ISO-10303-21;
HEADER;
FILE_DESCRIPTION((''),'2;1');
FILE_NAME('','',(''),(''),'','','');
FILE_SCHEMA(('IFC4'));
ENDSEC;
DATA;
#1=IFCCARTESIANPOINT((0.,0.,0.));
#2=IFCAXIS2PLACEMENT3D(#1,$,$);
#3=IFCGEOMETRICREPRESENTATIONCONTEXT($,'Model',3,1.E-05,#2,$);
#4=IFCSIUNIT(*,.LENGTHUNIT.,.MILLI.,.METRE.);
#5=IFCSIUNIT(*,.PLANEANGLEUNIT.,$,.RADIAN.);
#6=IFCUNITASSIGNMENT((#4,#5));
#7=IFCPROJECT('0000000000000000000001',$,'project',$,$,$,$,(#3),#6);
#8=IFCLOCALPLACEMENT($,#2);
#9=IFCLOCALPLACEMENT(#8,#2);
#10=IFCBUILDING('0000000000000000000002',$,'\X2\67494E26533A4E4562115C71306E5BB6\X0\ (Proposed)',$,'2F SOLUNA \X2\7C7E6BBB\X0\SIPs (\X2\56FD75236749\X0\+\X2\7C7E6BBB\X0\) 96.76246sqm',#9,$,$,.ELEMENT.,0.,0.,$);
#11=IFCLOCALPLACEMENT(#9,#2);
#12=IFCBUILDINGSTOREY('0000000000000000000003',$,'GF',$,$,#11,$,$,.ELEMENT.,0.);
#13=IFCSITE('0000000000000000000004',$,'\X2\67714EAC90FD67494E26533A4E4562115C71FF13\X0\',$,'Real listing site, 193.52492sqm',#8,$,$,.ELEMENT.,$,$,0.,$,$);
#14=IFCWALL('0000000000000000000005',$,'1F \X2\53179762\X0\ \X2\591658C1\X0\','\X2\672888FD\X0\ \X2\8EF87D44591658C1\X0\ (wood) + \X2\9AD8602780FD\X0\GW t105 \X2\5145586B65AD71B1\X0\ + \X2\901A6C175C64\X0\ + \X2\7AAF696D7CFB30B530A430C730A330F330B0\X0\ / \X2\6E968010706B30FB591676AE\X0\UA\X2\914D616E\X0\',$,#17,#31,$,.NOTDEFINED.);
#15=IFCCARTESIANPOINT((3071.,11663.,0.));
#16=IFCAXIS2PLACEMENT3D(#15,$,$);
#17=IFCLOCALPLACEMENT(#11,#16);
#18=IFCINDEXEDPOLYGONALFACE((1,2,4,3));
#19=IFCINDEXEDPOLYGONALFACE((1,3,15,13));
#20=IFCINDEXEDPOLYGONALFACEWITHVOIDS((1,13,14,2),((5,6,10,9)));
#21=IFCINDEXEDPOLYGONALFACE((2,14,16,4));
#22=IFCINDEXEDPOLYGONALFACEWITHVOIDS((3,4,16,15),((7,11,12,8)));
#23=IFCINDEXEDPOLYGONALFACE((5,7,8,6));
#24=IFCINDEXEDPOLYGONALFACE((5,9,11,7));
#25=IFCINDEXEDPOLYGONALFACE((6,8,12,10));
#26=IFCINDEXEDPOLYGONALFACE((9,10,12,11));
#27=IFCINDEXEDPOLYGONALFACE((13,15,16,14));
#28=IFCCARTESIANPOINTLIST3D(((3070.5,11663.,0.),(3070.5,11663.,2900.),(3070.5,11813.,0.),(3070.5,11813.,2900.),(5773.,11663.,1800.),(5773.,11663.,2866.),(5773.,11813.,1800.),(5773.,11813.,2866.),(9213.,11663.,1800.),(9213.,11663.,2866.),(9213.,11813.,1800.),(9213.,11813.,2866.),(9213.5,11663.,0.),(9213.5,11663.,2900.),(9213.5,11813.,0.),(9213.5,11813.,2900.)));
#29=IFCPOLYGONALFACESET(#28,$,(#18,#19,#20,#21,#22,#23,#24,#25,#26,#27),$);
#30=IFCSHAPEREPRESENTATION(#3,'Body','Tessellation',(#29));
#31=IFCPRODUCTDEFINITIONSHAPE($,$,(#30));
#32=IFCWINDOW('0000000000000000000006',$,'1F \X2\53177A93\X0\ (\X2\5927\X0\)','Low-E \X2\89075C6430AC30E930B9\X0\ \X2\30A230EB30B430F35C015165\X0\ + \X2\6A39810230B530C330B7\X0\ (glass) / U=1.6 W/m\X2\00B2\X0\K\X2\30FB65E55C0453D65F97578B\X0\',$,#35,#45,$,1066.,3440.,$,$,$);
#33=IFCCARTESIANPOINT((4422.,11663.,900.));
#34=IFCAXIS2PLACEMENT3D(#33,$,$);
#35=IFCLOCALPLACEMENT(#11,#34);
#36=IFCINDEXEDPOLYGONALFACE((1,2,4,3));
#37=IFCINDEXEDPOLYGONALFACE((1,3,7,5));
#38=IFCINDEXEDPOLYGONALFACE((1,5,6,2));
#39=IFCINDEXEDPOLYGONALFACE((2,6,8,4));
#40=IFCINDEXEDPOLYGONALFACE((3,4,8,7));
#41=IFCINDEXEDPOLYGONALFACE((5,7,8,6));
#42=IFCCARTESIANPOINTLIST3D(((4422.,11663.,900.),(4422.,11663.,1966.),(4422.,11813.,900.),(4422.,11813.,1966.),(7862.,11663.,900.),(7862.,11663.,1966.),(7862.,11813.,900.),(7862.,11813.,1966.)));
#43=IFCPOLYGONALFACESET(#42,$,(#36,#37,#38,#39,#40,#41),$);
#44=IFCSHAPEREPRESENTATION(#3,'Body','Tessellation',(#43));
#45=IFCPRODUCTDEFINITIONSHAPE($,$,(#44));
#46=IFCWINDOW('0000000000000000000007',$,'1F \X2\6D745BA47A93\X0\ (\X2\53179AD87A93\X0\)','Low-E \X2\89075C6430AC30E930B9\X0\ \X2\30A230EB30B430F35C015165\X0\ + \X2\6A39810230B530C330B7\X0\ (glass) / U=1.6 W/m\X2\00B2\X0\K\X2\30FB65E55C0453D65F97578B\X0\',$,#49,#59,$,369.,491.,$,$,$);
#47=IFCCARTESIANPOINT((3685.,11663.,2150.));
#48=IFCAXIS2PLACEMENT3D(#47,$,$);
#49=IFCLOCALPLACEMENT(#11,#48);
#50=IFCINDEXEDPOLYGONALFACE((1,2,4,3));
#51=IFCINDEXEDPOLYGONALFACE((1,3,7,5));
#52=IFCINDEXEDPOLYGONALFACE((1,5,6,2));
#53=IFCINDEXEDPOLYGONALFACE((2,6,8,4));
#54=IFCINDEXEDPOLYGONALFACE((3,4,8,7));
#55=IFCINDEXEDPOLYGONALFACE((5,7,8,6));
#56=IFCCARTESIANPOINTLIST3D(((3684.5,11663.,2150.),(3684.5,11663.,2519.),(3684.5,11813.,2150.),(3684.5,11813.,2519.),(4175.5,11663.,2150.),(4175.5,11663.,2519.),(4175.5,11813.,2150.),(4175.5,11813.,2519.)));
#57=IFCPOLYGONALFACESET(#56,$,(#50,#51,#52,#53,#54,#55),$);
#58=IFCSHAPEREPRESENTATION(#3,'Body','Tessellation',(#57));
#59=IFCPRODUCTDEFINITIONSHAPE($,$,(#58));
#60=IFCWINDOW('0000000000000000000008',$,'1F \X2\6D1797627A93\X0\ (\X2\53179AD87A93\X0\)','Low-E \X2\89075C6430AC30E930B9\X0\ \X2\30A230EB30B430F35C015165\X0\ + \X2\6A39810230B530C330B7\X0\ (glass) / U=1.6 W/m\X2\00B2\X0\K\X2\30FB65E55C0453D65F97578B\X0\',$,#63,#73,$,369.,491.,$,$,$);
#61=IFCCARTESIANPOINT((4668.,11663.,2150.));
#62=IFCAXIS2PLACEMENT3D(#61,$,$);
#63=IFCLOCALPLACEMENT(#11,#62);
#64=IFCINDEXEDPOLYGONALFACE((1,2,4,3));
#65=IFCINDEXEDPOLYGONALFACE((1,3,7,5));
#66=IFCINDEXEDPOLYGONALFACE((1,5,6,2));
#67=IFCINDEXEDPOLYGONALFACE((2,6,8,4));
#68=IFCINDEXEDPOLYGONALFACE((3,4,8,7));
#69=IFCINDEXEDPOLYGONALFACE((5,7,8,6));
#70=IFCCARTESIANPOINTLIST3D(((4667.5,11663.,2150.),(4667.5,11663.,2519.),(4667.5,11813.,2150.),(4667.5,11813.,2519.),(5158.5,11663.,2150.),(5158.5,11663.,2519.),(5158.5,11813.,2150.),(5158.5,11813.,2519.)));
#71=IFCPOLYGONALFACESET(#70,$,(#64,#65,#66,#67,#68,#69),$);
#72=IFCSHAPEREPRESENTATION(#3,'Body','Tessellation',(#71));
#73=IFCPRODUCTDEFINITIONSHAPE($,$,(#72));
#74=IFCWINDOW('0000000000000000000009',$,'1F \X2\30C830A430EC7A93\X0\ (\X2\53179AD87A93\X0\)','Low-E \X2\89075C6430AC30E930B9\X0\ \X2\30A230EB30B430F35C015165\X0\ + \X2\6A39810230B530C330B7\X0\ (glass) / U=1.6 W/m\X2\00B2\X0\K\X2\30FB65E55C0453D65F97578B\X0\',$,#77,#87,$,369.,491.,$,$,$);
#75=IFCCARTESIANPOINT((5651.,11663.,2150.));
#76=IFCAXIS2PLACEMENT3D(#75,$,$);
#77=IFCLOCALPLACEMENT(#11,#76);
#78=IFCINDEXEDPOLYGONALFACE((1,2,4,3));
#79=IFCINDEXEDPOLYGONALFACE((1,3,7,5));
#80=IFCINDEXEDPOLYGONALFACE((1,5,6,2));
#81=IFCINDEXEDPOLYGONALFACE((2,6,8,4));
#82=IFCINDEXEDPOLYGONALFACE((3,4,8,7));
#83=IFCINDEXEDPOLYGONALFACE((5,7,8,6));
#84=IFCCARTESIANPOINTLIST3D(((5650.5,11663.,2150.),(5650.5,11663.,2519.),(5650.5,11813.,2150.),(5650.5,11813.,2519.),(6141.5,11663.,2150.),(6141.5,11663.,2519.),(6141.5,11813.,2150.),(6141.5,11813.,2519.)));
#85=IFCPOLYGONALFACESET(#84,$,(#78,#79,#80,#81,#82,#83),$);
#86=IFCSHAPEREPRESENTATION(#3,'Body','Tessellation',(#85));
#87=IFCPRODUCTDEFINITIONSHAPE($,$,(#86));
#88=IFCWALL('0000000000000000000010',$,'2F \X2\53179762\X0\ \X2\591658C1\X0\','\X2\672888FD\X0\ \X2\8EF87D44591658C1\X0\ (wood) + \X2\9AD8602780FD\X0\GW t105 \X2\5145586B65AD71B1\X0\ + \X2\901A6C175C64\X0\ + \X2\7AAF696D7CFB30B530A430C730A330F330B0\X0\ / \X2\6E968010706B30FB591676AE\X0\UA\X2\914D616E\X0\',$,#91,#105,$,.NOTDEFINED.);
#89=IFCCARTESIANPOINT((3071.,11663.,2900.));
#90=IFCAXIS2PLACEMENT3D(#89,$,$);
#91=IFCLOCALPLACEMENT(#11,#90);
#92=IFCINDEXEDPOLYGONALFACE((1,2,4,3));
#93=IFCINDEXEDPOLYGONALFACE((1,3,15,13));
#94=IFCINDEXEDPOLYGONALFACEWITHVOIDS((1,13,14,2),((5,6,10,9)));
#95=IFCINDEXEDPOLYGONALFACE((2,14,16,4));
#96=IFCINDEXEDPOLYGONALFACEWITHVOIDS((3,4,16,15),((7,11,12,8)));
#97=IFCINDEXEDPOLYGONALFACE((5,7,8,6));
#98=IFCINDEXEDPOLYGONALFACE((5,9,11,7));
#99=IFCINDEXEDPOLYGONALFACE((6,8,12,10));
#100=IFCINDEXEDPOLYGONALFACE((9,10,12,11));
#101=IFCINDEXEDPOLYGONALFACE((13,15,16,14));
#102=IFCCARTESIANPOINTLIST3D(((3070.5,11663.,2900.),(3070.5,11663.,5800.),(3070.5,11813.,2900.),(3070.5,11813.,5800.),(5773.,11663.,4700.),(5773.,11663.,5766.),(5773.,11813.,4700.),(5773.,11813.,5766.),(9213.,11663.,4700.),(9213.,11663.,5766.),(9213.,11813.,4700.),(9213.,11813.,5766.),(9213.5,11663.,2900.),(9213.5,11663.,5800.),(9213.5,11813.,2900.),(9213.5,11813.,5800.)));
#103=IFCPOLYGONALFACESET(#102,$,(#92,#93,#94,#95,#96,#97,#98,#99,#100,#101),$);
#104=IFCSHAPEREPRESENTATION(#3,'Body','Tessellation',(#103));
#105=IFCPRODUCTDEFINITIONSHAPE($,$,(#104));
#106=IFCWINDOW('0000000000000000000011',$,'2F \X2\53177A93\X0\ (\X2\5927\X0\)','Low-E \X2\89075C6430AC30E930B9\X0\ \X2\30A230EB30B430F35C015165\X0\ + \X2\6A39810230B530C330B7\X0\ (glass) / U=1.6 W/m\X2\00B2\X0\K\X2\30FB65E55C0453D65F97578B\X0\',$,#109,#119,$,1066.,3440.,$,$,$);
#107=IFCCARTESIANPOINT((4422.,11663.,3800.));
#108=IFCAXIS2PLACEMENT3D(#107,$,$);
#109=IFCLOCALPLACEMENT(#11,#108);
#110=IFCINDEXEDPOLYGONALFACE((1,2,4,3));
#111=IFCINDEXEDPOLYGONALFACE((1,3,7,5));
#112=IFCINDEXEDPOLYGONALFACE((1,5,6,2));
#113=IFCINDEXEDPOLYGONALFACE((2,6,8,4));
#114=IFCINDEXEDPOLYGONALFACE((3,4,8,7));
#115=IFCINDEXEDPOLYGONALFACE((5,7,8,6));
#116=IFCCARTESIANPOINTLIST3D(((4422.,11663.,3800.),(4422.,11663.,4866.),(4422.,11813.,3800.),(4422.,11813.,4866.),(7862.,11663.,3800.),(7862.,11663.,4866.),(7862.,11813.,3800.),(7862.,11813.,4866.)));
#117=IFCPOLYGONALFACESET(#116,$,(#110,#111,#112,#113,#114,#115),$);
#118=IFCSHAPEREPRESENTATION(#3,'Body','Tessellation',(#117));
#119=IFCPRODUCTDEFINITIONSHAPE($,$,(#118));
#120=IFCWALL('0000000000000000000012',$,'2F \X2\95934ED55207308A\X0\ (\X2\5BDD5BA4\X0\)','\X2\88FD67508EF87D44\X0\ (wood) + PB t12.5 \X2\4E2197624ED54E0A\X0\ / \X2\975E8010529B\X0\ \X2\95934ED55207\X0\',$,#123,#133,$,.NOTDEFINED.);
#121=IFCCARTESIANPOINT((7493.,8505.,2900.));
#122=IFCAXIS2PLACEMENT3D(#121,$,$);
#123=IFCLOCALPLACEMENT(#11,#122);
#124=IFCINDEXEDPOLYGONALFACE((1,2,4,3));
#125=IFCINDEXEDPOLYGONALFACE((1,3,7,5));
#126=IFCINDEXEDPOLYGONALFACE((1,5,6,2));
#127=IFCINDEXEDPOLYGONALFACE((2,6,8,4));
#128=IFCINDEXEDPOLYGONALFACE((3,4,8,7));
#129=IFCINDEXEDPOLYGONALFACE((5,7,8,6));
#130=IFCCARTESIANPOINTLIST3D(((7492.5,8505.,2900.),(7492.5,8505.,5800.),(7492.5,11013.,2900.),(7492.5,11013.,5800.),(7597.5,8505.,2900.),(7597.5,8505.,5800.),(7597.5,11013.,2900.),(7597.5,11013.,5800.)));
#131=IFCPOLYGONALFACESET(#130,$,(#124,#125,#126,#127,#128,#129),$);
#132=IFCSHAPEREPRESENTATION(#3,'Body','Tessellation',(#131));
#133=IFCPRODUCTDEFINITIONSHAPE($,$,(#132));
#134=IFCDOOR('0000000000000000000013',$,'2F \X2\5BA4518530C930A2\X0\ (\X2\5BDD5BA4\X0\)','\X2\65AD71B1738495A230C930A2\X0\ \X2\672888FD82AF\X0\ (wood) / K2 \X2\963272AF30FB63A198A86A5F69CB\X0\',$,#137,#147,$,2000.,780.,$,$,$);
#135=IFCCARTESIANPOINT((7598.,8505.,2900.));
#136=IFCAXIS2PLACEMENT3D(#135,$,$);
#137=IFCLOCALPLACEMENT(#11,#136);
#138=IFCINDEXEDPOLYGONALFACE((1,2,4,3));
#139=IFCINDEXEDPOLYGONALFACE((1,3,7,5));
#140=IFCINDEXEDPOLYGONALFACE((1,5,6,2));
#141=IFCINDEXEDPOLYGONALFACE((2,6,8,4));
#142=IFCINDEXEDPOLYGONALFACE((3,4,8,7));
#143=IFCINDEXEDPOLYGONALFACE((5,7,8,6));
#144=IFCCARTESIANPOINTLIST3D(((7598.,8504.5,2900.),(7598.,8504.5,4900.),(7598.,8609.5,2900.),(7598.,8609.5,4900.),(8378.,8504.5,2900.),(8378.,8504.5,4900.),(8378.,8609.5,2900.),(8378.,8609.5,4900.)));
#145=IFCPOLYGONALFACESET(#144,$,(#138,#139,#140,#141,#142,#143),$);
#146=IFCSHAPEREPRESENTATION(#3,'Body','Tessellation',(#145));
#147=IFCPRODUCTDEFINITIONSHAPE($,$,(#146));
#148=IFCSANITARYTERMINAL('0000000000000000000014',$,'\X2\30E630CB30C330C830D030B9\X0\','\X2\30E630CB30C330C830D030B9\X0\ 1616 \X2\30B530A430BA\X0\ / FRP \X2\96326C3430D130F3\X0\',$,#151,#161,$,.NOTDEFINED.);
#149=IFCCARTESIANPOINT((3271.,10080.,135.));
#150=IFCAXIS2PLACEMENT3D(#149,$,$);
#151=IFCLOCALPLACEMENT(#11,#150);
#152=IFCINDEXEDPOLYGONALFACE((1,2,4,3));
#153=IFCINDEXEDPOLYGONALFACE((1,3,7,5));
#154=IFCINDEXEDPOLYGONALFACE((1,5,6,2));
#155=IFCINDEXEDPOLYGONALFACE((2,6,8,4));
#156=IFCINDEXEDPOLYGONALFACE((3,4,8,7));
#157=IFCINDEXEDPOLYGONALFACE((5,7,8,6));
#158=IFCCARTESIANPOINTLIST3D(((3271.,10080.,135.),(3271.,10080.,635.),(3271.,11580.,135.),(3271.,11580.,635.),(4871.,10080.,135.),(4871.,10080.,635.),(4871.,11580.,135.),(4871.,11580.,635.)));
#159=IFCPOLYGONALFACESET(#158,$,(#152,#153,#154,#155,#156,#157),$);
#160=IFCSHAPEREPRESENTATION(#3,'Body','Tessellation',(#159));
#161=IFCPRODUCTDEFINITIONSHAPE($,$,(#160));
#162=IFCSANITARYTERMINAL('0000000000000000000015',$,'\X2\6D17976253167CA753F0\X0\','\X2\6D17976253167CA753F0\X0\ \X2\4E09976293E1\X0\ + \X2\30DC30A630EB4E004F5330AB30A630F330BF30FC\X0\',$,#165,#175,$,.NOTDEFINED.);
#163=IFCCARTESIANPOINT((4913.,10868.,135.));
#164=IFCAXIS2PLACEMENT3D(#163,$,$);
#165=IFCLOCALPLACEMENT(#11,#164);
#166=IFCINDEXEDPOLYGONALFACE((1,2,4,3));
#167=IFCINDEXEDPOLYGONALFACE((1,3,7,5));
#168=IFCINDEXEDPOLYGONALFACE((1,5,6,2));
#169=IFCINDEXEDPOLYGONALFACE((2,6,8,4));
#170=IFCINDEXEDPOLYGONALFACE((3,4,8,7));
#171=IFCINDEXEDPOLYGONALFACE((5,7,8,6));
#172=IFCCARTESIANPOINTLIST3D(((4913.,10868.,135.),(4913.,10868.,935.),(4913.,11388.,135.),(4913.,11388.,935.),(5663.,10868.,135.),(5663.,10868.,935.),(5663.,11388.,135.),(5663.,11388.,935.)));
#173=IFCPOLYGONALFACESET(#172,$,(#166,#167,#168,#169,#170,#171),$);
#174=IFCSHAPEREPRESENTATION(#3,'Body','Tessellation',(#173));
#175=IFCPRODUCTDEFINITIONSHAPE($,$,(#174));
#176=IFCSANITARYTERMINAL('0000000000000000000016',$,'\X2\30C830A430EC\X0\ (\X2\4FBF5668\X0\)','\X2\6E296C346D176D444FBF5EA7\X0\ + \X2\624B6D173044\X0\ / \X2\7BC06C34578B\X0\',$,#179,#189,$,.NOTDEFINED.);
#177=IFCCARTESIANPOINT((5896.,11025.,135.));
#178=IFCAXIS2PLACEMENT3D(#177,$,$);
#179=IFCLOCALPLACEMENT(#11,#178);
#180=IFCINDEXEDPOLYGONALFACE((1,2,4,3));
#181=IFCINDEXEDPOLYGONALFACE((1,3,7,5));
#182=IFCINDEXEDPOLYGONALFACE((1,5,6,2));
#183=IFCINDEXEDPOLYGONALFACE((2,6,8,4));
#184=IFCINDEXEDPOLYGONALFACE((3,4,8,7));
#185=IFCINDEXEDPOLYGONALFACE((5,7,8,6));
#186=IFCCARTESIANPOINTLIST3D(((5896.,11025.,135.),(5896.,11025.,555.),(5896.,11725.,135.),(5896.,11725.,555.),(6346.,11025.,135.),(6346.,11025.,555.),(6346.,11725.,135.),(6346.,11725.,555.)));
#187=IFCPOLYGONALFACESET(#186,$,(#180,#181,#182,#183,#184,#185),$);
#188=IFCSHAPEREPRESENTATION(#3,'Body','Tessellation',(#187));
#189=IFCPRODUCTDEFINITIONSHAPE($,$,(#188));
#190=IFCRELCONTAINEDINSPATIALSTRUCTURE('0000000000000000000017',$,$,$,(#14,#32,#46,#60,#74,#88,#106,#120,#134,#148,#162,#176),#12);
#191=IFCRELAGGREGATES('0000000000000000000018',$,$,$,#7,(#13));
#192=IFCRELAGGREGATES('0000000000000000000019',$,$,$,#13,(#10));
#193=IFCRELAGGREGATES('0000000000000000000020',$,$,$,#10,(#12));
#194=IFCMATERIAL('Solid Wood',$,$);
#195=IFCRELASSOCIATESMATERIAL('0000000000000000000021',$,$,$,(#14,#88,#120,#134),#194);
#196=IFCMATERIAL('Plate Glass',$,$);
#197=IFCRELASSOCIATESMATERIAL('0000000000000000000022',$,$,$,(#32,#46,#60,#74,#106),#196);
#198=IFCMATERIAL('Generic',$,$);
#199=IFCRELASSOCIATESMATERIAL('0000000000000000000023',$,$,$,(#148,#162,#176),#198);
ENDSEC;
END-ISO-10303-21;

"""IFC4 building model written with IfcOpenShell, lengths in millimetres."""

from ifc_helpers import new_model, si_unit, frame, frame_2d, origin, place, context, project, spatial, rectangle, extrude, material, element, fill, save


model = new_model("IFC4")

# Units and contexts
model_context = context("Model", 3, precision=1e-05, world=origin())
ifc_project = project(units=[si_unit("LENGTHUNIT", "METRE", prefix="MILLI"), si_unit("PLANEANGLEUNIT", "RADIAN")], contexts=[model_context])

# Site, building, storey
site_placement = place(None, origin())
site = spatial("IfcSite", under=ifc_project, at=site_placement, Name="東京都杉並区久我山３", ObjectType="Real listing site, 193.52492sqm", CompositionType="ELEMENT", RefElevation=0.0)
building_placement = place(site_placement, origin())
building = spatial("IfcBuilding", under=site, at=building_placement, Name="杉並区久我山の家 (Proposed)", ObjectType="2F SOLUNA 籾殻SIPs (国産杉+籾殻) 96.76246sqm", CompositionType="ELEMENT", ElevationOfRefHeight=0.0, ElevationOfTerrain=0.0)
storey_placement = place(building_placement, origin())
storey = spatial("IfcBuildingStorey", under=building, at=storey_placement, Name="GF", CompositionType="ELEMENT", Elevation=0.0)

# Wall, openings, windows
ifc_material_1 = material(Name="Solid Wood")
wall_1_placement = place(storey_placement, frame((3071.0, 11663.0, 0.0)))
wall_1 = element("IfcWall", 1, at=wall_1_placement, inside=storey, material=ifc_material_1, Name="1F 北面 外壁", Description="木製 軸組外壁 (wood) + 高性能GW t105 充填断熱 + 通気層 + 窯業系サイディング / 準耐火・外皮UA配慮", PredefinedType="NOTDEFINED", context=model_context, shape_type="SweptSolid", body=[
    extrude(rectangle(XDim=6143.0, YDim=150.0, at=frame_2d((3071.0, 75.0))), frame((3071.0, 11663.0, 0.0)), (0.0, 0.0, 1.0), 2900.0),
])
opening_1_placement = place(storey_placement, frame((4422.0, 11663.0, 900.0)))
opening_1 = element("IfcOpeningElement", 2, at=opening_1_placement, cuts=wall_1, PredefinedType="NOTDEFINED", context=model_context, shape_type="SweptSolid", body=[
    extrude(rectangle(XDim=3440.0, YDim=150.0, at=frame_2d((1720.0, 75.0))), frame((4422.0, 11663.0, 900.0)), (0.0, 0.0, 1.0), 1066.0),
])
opening_2_placement = place(storey_placement, frame((3685.0, 11663.0, 2150.0)))
opening_2 = element("IfcOpeningElement", 3, at=opening_2_placement, cuts=wall_1, PredefinedType="NOTDEFINED", context=model_context, shape_type="SweptSolid", body=[
    extrude(rectangle(XDim=491.0, YDim=150.0, at=frame_2d((245.0, 75.0))), frame((3685.0, 11663.0, 2150.0)), (0.0, 0.0, 1.0), 369.0),
])
opening_3_placement = place(storey_placement, frame((4668.0, 11663.0, 2150.0)))
opening_3 = element("IfcOpeningElement", 4, at=opening_3_placement, cuts=wall_1, PredefinedType="NOTDEFINED", context=model_context, shape_type="SweptSolid", body=[
    extrude(rectangle(XDim=491.0, YDim=150.0, at=frame_2d((245.0, 75.0))), frame((4668.0, 11663.0, 2150.0)), (0.0, 0.0, 1.0), 369.0),
])
opening_4_placement = place(storey_placement, frame((5651.0, 11663.0, 2150.0)))
opening_4 = element("IfcOpeningElement", 5, at=opening_4_placement, cuts=wall_1, PredefinedType="NOTDEFINED", context=model_context, shape_type="SweptSolid", body=[
    extrude(rectangle(XDim=491.0, YDim=150.0, at=frame_2d((245.0, 75.0))), frame((5651.0, 11663.0, 2150.0)), (0.0, 0.0, 1.0), 369.0),
])
ifc_material_2 = material(Name="Plate Glass")
window_1_placement = place(storey_placement, frame((4422.0, 11663.0, 900.0)))
window_1 = element("IfcWindow", 6, at=window_1_placement, inside=storey, material=ifc_material_2, Name="1F 北窓 (大)", Description="Low-E 複層ガラス アルゴン封入 + 樹脂サッシ (glass) / U=1.6 W/m²K・日射取得型", OverallHeight=1066.0, OverallWidth=3440.0, context=model_context, shape_type="SweptSolid", body=[
    extrude(rectangle(XDim=3440.0, YDim=150.0, at=frame_2d((1720.0, 75.0))), frame((4422.0, 11663.0, 900.0)), (0.0, 0.0, 1.0), 1066.0),
])
fill(opening_1, window_1)
window_2_placement = place(storey_placement, frame((3685.0, 11663.0, 2150.0)))
window_2 = element("IfcWindow", 7, at=window_2_placement, inside=storey, material=ifc_material_2, Name="1F 浴室窓 (北高窓)", Description="Low-E 複層ガラス アルゴン封入 + 樹脂サッシ (glass) / U=1.6 W/m²K・日射取得型", OverallHeight=369.0, OverallWidth=491.0, context=model_context, shape_type="SweptSolid", body=[
    extrude(rectangle(XDim=491.0, YDim=150.0, at=frame_2d((245.0, 75.0))), frame((3685.0, 11663.0, 2150.0)), (0.0, 0.0, 1.0), 369.0),
])
fill(opening_2, window_2)
window_3_placement = place(storey_placement, frame((4668.0, 11663.0, 2150.0)))
window_3 = element("IfcWindow", 8, at=window_3_placement, inside=storey, material=ifc_material_2, Name="1F 洗面窓 (北高窓)", Description="Low-E 複層ガラス アルゴン封入 + 樹脂サッシ (glass) / U=1.6 W/m²K・日射取得型", OverallHeight=369.0, OverallWidth=491.0, context=model_context, shape_type="SweptSolid", body=[
    extrude(rectangle(XDim=491.0, YDim=150.0, at=frame_2d((245.0, 75.0))), frame((4668.0, 11663.0, 2150.0)), (0.0, 0.0, 1.0), 369.0),
])
fill(opening_3, window_3)
window_4_placement = place(storey_placement, frame((5651.0, 11663.0, 2150.0)))
window_4 = element("IfcWindow", 9, at=window_4_placement, inside=storey, material=ifc_material_2, Name="1F トイレ窓 (北高窓)", Description="Low-E 複層ガラス アルゴン封入 + 樹脂サッシ (glass) / U=1.6 W/m²K・日射取得型", OverallHeight=369.0, OverallWidth=491.0, context=model_context, shape_type="SweptSolid", body=[
    extrude(rectangle(XDim=491.0, YDim=150.0, at=frame_2d((245.0, 75.0))), frame((5651.0, 11663.0, 2150.0)), (0.0, 0.0, 1.0), 369.0),
])
fill(opening_4, window_4)

# Wall, opening, window
wall_2_placement = place(storey_placement, frame((3071.0, 11663.0, 2900.0)))
wall_2 = element("IfcWall", 10, at=wall_2_placement, inside=storey, material=ifc_material_1, Name="2F 北面 外壁", Description="木製 軸組外壁 (wood) + 高性能GW t105 充填断熱 + 通気層 + 窯業系サイディング / 準耐火・外皮UA配慮", PredefinedType="NOTDEFINED", context=model_context, shape_type="SweptSolid", body=[
    extrude(rectangle(XDim=6143.0, YDim=150.0, at=frame_2d((3071.0, 75.0))), frame((3071.0, 11663.0, 2900.0)), (0.0, 0.0, 1.0), 2900.0),
])
opening_5_placement = place(storey_placement, frame((4422.0, 11663.0, 3800.0)))
opening_5 = element("IfcOpeningElement", 11, at=opening_5_placement, cuts=wall_2, PredefinedType="NOTDEFINED", context=model_context, shape_type="SweptSolid", body=[
    extrude(rectangle(XDim=3440.0, YDim=150.0, at=frame_2d((1720.0, 75.0))), frame((4422.0, 11663.0, 3800.0)), (0.0, 0.0, 1.0), 1066.0),
])
window_5_placement = place(storey_placement, frame((4422.0, 11663.0, 3800.0)))
window_5 = element("IfcWindow", 12, at=window_5_placement, inside=storey, material=ifc_material_2, Name="2F 北窓 (大)", Description="Low-E 複層ガラス アルゴン封入 + 樹脂サッシ (glass) / U=1.6 W/m²K・日射取得型", OverallHeight=1066.0, OverallWidth=3440.0, context=model_context, shape_type="SweptSolid", body=[
    extrude(rectangle(XDim=3440.0, YDim=150.0, at=frame_2d((1720.0, 75.0))), frame((4422.0, 11663.0, 3800.0)), (0.0, 0.0, 1.0), 1066.0),
])
fill(opening_5, window_5)

# Wall
wall_3_placement = place(storey_placement, frame((7493.0, 8505.0, 2900.0)))
element("IfcWall", 13, at=wall_3_placement, inside=storey, material=ifc_material_1, Name="2F 間仕切り (寝室)", Description="製材軸組 (wood) + PB t12.5 両面仕上 / 非耐力 間仕切", PredefinedType="NOTDEFINED", context=model_context, shape_type="SweptSolid", body=[
    extrude(rectangle(XDim=105.0, YDim=2508.0, at=frame_2d((52.0, 1254.0))), frame((7493.0, 8505.0, 2900.0)), (0.0, 0.0, 1.0), 2900.0),
])

# Door
door_1_placement = place(storey_placement, frame((7598.0, 8505.0, 2900.0)))
element("IfcDoor", 14, at=door_1_placement, inside=storey, material=ifc_material_1, Name="2F 室内ドア (寝室)", Description="断熱玄関ドア 木製芯 (wood) / K2 防犯・採風機構", OverallHeight=2000.0, OverallWidth=780.0, context=model_context, shape_type="SweptSolid", body=[
    extrude(rectangle(XDim=780.0, YDim=105.0, at=frame_2d((390.0, 52.0))), frame((7598.0, 8505.0, 2900.0)), (0.0, 0.0, 1.0), 2000.0),
])

# Sanitary terminals
ifc_material_3 = material(Name="Generic")
sanitary_terminal_1_placement = place(storey_placement, frame((3271.0, 10080.0, 135.0)))
element("IfcSanitaryTerminal", 15, at=sanitary_terminal_1_placement, inside=storey, material=ifc_material_3, Name="ユニットバス", Description="ユニットバス 1616 サイズ / FRP 防水パン", PredefinedType="NOTDEFINED", context=model_context, shape_type="SweptSolid", body=[
    extrude(rectangle(XDim=1600.0, YDim=1500.0, at=frame_2d((800.0, 750.0))), frame((3271.0, 10080.0, 135.0)), (0.0, 0.0, 1.0), 500.0),
])
sanitary_terminal_2_placement = place(storey_placement, frame((4913.0, 10868.0, 135.0)))
element("IfcSanitaryTerminal", 16, at=sanitary_terminal_2_placement, inside=storey, material=ifc_material_3, Name="洗面化粧台", Description="洗面化粧台 三面鏡 + ボウル一体カウンター", PredefinedType="NOTDEFINED", context=model_context, shape_type="SweptSolid", body=[
    extrude(rectangle(XDim=750.0, YDim=520.0, at=frame_2d((375.0, 260.0))), frame((4913.0, 10868.0, 135.0)), (0.0, 0.0, 1.0), 800.0),
])
sanitary_terminal_3_placement = place(storey_placement, frame((5896.0, 11025.0, 135.0)))
element("IfcSanitaryTerminal", 17, at=sanitary_terminal_3_placement, inside=storey, material=ifc_material_3, Name="トイレ (便器)", Description="温水洗浄便座 + 手洗い / 節水型", PredefinedType="NOTDEFINED", context=model_context, shape_type="SweptSolid", body=[
    extrude(rectangle(XDim=450.0, YDim=700.0, at=frame_2d((225.0, 350.0))), frame((5896.0, 11025.0, 135.0)), (0.0, 0.0, 1.0), 420.0),
])

save(model, "model.ifc")
